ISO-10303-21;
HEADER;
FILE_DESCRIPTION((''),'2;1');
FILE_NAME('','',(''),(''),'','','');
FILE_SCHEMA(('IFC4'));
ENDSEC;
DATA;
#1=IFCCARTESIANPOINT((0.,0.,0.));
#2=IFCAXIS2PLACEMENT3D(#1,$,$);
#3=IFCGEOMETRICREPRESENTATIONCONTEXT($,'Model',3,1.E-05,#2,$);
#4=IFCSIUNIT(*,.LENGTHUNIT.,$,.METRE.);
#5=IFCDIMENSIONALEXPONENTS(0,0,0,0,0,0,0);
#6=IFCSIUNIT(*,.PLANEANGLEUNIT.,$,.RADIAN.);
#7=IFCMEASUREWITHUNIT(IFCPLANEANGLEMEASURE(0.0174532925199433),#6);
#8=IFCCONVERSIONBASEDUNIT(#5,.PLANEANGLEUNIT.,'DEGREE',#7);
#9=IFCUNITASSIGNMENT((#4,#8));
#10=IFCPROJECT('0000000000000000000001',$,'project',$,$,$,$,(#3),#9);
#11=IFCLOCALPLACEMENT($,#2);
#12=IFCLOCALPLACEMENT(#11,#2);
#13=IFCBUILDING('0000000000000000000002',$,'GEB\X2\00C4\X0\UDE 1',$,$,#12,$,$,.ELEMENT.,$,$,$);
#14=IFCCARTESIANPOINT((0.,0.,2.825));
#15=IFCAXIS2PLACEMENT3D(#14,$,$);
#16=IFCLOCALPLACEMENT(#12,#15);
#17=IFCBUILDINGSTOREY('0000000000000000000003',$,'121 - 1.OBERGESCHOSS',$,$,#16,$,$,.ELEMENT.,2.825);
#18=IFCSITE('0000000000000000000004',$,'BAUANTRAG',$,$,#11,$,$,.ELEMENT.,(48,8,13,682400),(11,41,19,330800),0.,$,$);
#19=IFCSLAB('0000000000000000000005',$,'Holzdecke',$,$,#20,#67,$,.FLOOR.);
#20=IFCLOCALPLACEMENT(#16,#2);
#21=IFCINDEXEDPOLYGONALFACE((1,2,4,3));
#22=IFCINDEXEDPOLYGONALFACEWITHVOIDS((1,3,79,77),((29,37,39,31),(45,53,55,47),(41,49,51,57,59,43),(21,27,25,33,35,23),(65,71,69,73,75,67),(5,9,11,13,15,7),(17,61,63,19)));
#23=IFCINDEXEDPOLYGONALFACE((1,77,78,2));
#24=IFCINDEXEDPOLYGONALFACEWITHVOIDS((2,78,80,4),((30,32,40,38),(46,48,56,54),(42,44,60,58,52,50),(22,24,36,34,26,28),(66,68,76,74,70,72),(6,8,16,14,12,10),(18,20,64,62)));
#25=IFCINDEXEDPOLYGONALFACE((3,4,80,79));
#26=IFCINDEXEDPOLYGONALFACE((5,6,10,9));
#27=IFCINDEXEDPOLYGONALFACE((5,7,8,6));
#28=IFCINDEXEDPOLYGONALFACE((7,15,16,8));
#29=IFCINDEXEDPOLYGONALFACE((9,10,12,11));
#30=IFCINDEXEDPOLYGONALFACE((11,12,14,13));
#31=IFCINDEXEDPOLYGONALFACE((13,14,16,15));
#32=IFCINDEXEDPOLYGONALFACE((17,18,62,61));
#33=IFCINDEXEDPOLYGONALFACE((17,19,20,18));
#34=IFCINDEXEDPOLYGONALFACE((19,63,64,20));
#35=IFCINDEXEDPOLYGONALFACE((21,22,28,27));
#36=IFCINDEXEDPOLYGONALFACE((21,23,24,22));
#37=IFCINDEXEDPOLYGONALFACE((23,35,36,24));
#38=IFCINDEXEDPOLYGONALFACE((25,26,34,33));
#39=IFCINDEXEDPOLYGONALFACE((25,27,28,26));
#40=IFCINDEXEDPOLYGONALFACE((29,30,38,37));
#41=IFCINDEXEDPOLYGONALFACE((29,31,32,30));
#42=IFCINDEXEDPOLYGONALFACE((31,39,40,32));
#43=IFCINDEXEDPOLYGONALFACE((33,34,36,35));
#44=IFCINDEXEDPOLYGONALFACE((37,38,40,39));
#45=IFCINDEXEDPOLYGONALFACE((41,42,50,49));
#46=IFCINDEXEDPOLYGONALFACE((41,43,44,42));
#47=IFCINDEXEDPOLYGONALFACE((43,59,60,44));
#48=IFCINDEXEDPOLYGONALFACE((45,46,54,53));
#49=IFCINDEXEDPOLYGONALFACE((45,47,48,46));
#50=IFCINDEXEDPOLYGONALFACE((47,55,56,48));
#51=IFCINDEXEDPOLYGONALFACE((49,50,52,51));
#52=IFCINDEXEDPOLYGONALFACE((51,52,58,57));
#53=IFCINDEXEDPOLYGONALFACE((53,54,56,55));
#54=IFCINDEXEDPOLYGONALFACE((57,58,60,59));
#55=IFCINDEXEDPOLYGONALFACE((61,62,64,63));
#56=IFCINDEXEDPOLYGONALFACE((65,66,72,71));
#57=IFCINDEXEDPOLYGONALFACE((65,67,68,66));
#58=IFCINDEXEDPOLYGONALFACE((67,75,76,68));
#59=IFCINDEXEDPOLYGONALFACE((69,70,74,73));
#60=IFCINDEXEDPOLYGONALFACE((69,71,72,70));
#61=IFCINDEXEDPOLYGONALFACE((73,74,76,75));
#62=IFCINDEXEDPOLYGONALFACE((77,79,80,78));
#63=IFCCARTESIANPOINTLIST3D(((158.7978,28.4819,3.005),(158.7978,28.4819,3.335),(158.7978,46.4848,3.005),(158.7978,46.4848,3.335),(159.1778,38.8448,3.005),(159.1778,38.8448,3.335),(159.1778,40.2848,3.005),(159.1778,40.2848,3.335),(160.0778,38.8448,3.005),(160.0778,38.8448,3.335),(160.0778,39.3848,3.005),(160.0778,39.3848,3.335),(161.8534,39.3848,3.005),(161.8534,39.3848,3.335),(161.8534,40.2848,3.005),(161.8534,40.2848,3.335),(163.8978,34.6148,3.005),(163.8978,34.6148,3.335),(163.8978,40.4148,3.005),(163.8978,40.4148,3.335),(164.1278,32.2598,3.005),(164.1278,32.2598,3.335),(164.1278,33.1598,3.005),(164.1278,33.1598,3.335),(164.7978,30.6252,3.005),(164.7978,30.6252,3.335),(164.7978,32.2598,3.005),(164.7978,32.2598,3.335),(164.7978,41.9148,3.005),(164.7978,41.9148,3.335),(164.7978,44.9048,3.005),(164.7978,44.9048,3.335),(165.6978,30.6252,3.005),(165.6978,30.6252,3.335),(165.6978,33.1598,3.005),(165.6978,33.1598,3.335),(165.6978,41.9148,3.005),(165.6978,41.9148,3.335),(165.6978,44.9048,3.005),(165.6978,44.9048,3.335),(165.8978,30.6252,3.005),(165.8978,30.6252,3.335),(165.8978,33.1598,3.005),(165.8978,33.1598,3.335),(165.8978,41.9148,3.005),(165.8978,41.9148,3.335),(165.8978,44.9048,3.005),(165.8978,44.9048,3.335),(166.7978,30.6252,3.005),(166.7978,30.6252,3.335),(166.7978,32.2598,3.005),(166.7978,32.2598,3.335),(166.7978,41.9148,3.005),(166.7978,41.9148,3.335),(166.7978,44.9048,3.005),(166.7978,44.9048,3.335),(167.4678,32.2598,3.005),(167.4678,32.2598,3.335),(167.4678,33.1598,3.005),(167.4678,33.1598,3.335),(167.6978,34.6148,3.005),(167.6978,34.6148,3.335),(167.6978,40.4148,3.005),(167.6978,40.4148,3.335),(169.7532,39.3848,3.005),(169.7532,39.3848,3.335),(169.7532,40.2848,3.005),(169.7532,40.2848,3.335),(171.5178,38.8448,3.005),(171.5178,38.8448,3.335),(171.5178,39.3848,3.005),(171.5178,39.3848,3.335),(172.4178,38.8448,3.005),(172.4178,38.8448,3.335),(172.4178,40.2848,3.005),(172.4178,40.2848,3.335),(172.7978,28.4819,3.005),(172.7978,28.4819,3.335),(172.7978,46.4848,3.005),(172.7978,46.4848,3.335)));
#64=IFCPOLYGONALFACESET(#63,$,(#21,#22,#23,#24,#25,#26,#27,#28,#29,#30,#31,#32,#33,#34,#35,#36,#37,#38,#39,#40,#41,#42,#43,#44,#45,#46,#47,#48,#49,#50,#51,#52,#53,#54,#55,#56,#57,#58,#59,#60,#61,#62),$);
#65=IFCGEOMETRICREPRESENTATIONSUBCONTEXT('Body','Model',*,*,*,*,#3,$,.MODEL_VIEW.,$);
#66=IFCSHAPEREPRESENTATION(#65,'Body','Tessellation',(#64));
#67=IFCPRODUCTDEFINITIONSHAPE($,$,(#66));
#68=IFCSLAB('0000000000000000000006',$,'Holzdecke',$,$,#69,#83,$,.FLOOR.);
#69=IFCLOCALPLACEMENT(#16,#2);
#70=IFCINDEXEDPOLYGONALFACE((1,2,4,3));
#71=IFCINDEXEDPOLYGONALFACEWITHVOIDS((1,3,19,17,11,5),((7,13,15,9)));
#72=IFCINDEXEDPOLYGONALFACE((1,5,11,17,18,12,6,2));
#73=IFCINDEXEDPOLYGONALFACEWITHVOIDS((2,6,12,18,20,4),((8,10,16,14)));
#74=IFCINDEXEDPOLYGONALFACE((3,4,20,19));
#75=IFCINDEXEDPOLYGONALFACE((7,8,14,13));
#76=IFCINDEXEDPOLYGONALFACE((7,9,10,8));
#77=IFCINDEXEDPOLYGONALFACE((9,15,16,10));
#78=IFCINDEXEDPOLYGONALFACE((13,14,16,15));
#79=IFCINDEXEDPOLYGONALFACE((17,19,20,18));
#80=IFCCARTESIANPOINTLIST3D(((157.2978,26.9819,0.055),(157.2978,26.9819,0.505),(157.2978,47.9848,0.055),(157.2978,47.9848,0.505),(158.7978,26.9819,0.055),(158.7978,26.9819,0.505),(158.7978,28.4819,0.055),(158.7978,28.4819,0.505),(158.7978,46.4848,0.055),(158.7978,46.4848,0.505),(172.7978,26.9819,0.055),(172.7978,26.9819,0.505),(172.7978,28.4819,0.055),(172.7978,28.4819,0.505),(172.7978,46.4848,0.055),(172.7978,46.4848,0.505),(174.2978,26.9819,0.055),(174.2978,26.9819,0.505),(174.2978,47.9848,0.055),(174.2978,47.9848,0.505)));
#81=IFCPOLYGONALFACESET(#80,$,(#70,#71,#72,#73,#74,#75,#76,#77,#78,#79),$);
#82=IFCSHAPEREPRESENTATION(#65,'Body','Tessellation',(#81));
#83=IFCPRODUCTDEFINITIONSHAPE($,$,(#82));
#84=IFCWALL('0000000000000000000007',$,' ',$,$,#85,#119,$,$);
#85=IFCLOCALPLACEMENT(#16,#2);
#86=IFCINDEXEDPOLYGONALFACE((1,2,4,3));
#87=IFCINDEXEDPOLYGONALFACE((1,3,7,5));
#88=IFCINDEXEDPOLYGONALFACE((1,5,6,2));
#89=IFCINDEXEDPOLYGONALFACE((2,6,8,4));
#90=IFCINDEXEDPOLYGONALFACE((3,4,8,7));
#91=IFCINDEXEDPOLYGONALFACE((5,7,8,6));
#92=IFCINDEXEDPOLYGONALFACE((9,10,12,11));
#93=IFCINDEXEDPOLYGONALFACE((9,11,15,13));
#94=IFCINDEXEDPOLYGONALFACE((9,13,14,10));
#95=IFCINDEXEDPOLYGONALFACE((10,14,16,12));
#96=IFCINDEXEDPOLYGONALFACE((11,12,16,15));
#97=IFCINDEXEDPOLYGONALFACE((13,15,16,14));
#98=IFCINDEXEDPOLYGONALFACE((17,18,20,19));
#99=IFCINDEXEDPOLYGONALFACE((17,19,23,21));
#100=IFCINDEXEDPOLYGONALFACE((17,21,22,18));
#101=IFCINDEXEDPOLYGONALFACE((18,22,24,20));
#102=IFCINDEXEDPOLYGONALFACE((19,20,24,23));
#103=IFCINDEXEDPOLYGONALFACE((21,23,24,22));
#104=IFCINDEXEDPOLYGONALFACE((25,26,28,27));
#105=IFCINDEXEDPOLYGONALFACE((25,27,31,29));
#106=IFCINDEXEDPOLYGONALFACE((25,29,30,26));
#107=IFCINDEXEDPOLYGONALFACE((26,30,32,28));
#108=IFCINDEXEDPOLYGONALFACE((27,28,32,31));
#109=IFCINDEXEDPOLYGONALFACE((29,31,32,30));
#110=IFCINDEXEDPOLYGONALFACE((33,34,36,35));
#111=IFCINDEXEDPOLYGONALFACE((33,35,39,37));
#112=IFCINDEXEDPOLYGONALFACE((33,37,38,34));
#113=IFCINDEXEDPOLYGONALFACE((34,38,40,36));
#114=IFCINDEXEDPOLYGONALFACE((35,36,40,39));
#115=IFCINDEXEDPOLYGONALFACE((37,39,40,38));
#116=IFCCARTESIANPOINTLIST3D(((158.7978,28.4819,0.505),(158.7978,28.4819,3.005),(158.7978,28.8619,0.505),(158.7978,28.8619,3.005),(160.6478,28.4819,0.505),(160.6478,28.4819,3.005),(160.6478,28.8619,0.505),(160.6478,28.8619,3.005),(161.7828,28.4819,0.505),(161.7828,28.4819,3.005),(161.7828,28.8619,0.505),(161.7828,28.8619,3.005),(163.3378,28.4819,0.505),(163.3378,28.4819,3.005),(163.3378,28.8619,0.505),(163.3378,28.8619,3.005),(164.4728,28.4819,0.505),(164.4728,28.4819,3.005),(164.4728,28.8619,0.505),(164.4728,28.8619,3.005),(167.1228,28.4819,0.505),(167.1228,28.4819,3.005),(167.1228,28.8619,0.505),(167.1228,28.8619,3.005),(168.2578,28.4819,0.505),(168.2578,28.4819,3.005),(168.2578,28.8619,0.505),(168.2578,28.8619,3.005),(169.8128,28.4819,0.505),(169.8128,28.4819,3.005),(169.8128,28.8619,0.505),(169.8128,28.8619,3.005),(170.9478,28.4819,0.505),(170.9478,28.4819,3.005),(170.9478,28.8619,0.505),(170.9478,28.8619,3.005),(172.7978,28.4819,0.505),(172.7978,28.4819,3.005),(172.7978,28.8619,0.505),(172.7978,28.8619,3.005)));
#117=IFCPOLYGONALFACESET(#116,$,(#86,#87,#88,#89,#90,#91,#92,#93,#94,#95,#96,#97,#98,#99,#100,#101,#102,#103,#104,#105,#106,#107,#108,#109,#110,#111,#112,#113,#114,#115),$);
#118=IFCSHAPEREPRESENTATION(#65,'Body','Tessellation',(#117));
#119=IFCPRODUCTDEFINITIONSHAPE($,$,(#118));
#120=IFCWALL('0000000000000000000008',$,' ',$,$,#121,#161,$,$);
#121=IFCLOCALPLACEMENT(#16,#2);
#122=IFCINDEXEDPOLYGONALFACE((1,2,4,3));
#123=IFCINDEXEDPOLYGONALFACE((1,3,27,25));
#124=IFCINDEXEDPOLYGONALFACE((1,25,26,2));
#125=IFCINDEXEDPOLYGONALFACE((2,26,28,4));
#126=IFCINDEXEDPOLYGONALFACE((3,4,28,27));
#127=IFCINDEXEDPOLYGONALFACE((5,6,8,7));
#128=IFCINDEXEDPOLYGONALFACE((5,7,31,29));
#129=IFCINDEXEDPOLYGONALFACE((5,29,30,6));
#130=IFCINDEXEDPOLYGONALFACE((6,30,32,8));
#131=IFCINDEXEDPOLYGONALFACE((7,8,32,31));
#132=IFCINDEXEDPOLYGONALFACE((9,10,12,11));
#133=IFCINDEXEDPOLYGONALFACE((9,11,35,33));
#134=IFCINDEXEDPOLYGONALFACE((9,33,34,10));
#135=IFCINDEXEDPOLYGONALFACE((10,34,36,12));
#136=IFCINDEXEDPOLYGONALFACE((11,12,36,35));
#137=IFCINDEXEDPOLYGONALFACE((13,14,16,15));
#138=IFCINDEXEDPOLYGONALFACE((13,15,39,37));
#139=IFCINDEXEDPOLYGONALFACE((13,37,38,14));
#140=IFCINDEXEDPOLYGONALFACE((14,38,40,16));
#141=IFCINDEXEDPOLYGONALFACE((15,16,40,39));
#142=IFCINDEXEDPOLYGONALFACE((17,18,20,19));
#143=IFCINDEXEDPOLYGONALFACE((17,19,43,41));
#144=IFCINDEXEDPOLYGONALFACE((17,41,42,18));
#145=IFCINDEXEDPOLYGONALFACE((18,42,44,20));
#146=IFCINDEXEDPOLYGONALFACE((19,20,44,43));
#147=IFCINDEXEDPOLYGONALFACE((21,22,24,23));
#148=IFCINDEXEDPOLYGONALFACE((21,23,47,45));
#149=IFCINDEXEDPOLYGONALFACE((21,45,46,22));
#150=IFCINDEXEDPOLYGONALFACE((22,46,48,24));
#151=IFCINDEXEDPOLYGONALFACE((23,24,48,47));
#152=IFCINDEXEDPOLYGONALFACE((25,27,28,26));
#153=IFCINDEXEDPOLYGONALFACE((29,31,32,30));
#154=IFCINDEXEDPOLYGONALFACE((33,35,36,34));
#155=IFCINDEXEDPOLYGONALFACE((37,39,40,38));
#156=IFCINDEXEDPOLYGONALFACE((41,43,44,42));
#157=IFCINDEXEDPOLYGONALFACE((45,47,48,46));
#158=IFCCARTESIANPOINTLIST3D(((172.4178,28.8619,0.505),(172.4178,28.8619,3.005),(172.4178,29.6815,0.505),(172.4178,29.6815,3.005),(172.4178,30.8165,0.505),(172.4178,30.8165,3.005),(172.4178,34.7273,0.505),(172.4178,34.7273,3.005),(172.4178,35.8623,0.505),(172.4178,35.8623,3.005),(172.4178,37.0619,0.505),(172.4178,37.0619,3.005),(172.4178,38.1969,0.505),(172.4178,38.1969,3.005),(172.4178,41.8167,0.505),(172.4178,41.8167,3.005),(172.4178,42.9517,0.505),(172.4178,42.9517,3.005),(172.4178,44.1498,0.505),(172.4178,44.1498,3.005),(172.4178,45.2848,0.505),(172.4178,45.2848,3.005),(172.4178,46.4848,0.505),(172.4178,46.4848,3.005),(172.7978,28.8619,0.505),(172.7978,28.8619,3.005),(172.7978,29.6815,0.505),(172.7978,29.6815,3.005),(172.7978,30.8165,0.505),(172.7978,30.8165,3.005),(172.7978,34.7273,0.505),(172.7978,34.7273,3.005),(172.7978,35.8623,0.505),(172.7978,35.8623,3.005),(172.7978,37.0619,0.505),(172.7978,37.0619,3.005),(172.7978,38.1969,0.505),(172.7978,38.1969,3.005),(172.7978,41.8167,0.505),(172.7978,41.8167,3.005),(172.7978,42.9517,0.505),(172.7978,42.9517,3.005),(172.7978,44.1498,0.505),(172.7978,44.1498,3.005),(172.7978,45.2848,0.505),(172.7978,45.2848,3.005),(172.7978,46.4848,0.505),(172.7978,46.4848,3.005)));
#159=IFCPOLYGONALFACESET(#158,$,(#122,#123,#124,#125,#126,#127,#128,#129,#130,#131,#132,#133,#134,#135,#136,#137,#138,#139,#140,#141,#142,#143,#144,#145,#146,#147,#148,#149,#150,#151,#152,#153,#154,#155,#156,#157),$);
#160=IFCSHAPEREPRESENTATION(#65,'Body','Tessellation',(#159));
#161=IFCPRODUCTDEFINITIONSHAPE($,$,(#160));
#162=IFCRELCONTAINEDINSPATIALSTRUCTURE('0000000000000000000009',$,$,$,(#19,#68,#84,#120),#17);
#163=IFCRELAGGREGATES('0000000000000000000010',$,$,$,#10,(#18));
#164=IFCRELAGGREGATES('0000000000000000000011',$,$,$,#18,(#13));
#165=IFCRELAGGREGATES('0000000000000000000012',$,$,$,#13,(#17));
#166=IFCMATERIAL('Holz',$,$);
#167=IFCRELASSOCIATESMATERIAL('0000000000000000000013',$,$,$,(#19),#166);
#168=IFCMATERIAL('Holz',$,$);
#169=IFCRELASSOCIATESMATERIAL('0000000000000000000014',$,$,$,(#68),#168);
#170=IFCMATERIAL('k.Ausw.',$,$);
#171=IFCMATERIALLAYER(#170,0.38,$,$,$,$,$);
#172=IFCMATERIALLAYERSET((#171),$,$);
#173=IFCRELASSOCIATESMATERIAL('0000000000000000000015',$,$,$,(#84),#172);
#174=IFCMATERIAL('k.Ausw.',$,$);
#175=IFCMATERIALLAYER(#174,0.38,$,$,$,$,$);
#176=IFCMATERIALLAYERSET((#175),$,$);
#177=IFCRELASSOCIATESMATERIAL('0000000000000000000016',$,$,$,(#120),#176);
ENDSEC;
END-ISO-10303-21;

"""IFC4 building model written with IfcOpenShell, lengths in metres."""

from ifc_helpers import new_model, entity, si_unit, converted_unit, frame, frame_2d, origin, origin_with_axes, place, context, subcontext, project, spatial, polyline, rectangle, outline, extrude, material, layer, layer_set, layer_usage, element, save


model = new_model("IFC4")

# Units and contexts
model_context = context("Model", 3, precision=1e-05, world=origin())
body_context = subcontext(model_context, "Body", "Model", "MODEL_VIEW")
ifc_project = project(units=[si_unit("LENGTHUNIT", "METRE"), converted_unit("PLANEANGLEUNIT", "DEGREE", entity("IfcPlaneAngleMeasure", 0.0174532925199433), si_unit("PLANEANGLEUNIT", "RADIAN"), dimensions=[0, 0, 0, 0, 0, 0, 0])], contexts=[model_context])

# Site, building, storey
site_placement = place(None, origin())
site = spatial("IfcSite", under=ifc_project, at=site_placement, Name="BAUANTRAG", CompositionType="ELEMENT", RefLatitude=(48, 8, 13, 682400), RefLongitude=(11, 41, 19, 330800), RefElevation=0.0)
building_placement = place(site_placement, origin())
building = spatial("IfcBuilding", under=site, at=building_placement, Name="GEBÄUDE 1", CompositionType="ELEMENT")
storey_placement = place(building_placement, frame((0.0, 0.0, 2.825)))
storey = spatial("IfcBuildingStorey", under=building, at=storey_placement, Name="121 - 1.OBERGESCHOSS", CompositionType="ELEMENT", Elevation=2.825)

# Slab, opening
ifc_material_1 = material(Name="Holz")
slab_1_placement = place(storey_placement, frame((158.7978, 28.4819, 3.005)))
slab_1 = element("IfcSlab", 1, at=slab_1_placement, inside=storey, material=ifc_material_1, Name="Holzdecke", PredefinedType="FLOOR", context=body_context, shape_type="SweptSolid", body=[
    extrude(outline(polyline([(0.0, 0.0), (14.0, 0.0), (14.0, 18.0029), (0.0, 18.0029), (0.0, 0.0)]), holes=[polyline([(8.9, 6.1329), (5.1, 6.1329), (5.1, 11.9329), (8.9, 11.9329), (8.9, 6.1329)]), polyline([(6.0, 2.1433), (6.0, 3.7779), (5.33, 3.7779), (5.33, 4.6779), (6.0, 4.6779), (6.9, 4.6779), (6.9, 2.1433), (6.0, 2.1433)]), polyline([(8.0, 2.1433), (7.1, 2.1433), (7.1, 4.6779), (8.0, 4.6779), (8.67, 4.6779), (8.67, 3.7779), (8.0, 3.7779), (8.0, 2.1433)]), polyline([(13.62, 10.3629), (12.72, 10.3629), (12.72, 10.9029), (10.9554, 10.9029), (10.9554, 11.8029), (13.62, 11.8029), (13.62, 10.3629)]), polyline([(7.1, 13.4329), (7.1, 16.4229), (8.0, 16.4229), (8.0, 13.4329), (7.1, 13.4329)]), polyline([(6.9, 13.4329), (6.0, 13.4329), (6.0, 16.4229), (6.9, 16.4229), (6.9, 13.4329)])]), origin_with_axes(), (0.0, 0.0, 1.0), 0.33),
])
opening_1_placement = place(slab_1_placement, frame((0.38, 10.3629, 0.0)))
element("IfcOpeningElement", 2, at=opening_1_placement, cuts=slab_1, ObjectType="Opening", context=body_context, shape_type="SweptSolid", body=[
    extrude(outline(polyline([(1.4838, 0.78), (-1.1919, 0.78), (-1.1919, -0.66), (-0.2919, -0.66), (-0.2919, -0.12), (1.4838, -0.12), (1.4838, 0.78)])), frame((1.1919, 0.66, 0.0), z_axis=(0.0, 0.0, 1.0), x_axis=(1.0, 0.0, 0.0)), (0.0, 0.0, 1.0), 0.33),
])

# Slab
ifc_material_2 = material(Name="Holz")
slab_2_placement = place(storey_placement, frame((157.2978, 26.9819, 0.055)))
element("IfcSlab", 3, at=slab_2_placement, inside=storey, material=ifc_material_2, Name="Holzdecke", PredefinedType="FLOOR", context=body_context, shape_type="SweptSolid", body=[
    extrude(outline(polyline([(17.0, 0.0), (17.0, 21.0029), (0.0, 21.0029), (0.0, 0.0), (1.5, 0.0), (15.5, 0.0), (17.0, 0.0)]), holes=[polyline([(15.5, 19.5029), (15.5, 1.5), (1.5, 1.5), (1.5, 19.5029), (15.5, 19.5029)])]), origin_with_axes(), (0.0, 0.0, 1.0), 0.45),
])

# Walls, openings
ifc_material_3 = material(Name="k.Ausw.")
ifc_layer_1 = layer(ifc_material_3, 0.38)
ifc_layer_set_1 = layer_set([ifc_layer_1])
ifc_layer_usage_1 = layer_usage(ifc_layer_set_1, "AXIS2", "POSITIVE", 0.0)
wall_1_placement = place(storey_placement, frame((158.7978, 28.4819, 0.505)))
wall_1 = element("IfcWall", 4, at=wall_1_placement, inside=storey, material=ifc_layer_usage_1, Name=" ", context=body_context, shape_type="SweptSolid", body=[
    extrude(rectangle(XDim=14.0, YDim=0.38, at=frame_2d((7.0, 0.19), x_axis=(1.0, 0.0))), origin_with_axes(), (0.0, 0.0, 1.0), 2.5),
])
opening_2_placement = place(wall_1_placement, frame((9.46, 0.38, 0.0), z_axis=(0.0, -1.0, 0.0), x_axis=(0.0, 0.0, 1.0)))
element("IfcOpeningElement", 5, at=opening_2_placement, cuts=wall_1, ObjectType="Opening", context=body_context, shape_type="SweptSolid", body=[
    extrude(outline(polyline([(0.0, 1.135), (2.5, 1.135), (2.5, 0.0), (0.0, 0.0), (0.0, 1.135)])), origin_with_axes(), (0.0, 0.0, 1.0), 0.38),
])
opening_3_placement = place(wall_1_placement, frame((5.675, 0.38, 0.0), z_axis=(0.0, -1.0, 0.0), x_axis=(0.0, 0.0, 1.0)))
element("IfcOpeningElement", 6, at=opening_3_placement, cuts=wall_1, ObjectType="Opening", context=body_context, shape_type="SweptSolid", body=[
    extrude(outline(polyline([(0.0, 1.135), (2.5, 1.135), (2.5, 0.0), (0.0, 0.0), (0.0, 1.135)])), origin_with_axes(), (0.0, 0.0, 1.0), 0.38),
])
opening_4_placement = place(wall_1_placement, frame((2.985, 0.38, 0.0), z_axis=(0.0, -1.0, 0.0), x_axis=(0.0, 0.0, 1.0)))
element("IfcOpeningElement", 7, at=opening_4_placement, cuts=wall_1, ObjectType="Opening", context=body_context, shape_type="SweptSolid", body=[
    extrude(outline(polyline([(0.0, 1.135), (2.5, 1.135), (2.5, 0.0), (0.0, 0.0), (0.0, 1.135)])), origin_with_axes(), (0.0, 0.0, 1.0), 0.38),
])
opening_5_placement = place(wall_1_placement, frame((12.15, 0.38, 0.0), z_axis=(0.0, -1.0, 0.0), x_axis=(0.0, 0.0, 1.0)))
element("IfcOpeningElement", 8, at=opening_5_placement, cuts=wall_1, ObjectType="Opening", context=body_context, shape_type="SweptSolid", body=[
    extrude(outline(polyline([(0.0, 1.135), (2.5, 1.135), (2.5, 0.0), (0.0, 0.0), (0.0, 1.135)])), origin_with_axes(), (0.0, 0.0, 1.0), 0.38),
])
ifc_material_4 = material(Name="k.Ausw.")
ifc_layer_2 = layer(ifc_material_4, 0.38)
ifc_layer_set_2 = layer_set([ifc_layer_2])
ifc_layer_usage_2 = layer_usage(ifc_layer_set_2, "AXIS2", "POSITIVE", 0.0)
wall_2_placement = place(storey_placement, frame((172.7978, 28.8619, 0.505), z_axis=(0.0, 0.0, 1.0), x_axis=(0.0, 1.0, 0.0)))
wall_2 = element("IfcWall", 9, at=wall_2_placement, inside=storey, material=ifc_layer_usage_2, Name=" ", context=body_context, shape_type="SweptSolid", body=[
    extrude(rectangle(XDim=17.6229, YDim=0.38, at=frame_2d((8.8114, 0.19), x_axis=(1.0, 0.0))), origin_with_axes(), (0.0, 0.0, 1.0), 2.5),
])
opening_6_placement = place(wall_2_placement, frame((14.0898, 0.38, 0.0), z_axis=(0.0, -1.0, 0.0), x_axis=(0.0, 0.0, 1.0)))
element("IfcOpeningElement", 10, at=opening_6_placement, cuts=wall_2, ObjectType="Opening", context=body_context, shape_type="SweptSolid", body=[
    extrude(outline(polyline([(0.0, 1.135), (2.5, 1.135), (2.5, 0.0), (0.0, 0.0), (0.0, 1.135)])), origin_with_axes(), (0.0, 0.0, 1.0), 0.38),
])
opening_7_placement = place(wall_2_placement, frame((16.4229, 0.38, 0.0), z_axis=(0.0, -1.0, 0.0), x_axis=(0.0, 0.0, 1.0)))
element("IfcOpeningElement", 11, at=opening_7_placement, cuts=wall_2, ObjectType="Opening", context=body_context, shape_type="SweptSolid", body=[
    extrude(outline(polyline([(0.0, 1.135), (2.5, 1.135), (2.5, 0.0), (0.0, 0.0), (0.0, 1.135)])), origin_with_axes(), (0.0, 0.0, 1.0), 0.38),
])
opening_8_placement = place(wall_2_placement, frame((1.9546, 0.38, 0.0), z_axis=(0.0, -1.0, 0.0), x_axis=(0.0, 0.0, 1.0)))
element("IfcOpeningElement", 12, at=opening_8_placement, cuts=wall_2, ObjectType="Opening", context=body_context, shape_type="SweptSolid", body=[
    extrude(outline(polyline([(0.0, 1.135), (2.5, 1.135), (2.5, 0.0), (0.0, 0.0), (0.0, 1.135)])), origin_with_axes(), (0.0, 0.0, 1.0), 0.38),
])
opening_9_placement = place(wall_2_placement, frame((9.335, 0.38, 0.0), z_axis=(0.0, -1.0, 0.0), x_axis=(0.0, 0.0, 1.0)))
element("IfcOpeningElement", 13, at=opening_9_placement, cuts=wall_2, ObjectType="Opening", context=body_context, shape_type="SweptSolid", body=[
    extrude(outline(polyline([(0.0, 1.135), (2.5, 1.135), (2.5, 0.0), (0.0, 0.0), (0.0, 1.135)])), origin_with_axes(), (0.0, 0.0, 1.0), 0.38),
])
opening_10_placement = place(wall_2_placement, frame((7.0004, 0.38, 0.0), z_axis=(0.0, -1.0, 0.0), x_axis=(0.0, 0.0, 1.0)))
element("IfcOpeningElement", 14, at=opening_10_placement, cuts=wall_2, ObjectType="Opening", context=body_context, shape_type="SweptSolid", body=[
    extrude(outline(polyline([(0.0, 1.135), (2.5, 1.135), (2.5, 0.0), (0.0, 0.0), (0.0, 1.135)])), origin_with_axes(), (0.0, 0.0, 1.0), 0.38),
])

save(model, "model.ifc")
